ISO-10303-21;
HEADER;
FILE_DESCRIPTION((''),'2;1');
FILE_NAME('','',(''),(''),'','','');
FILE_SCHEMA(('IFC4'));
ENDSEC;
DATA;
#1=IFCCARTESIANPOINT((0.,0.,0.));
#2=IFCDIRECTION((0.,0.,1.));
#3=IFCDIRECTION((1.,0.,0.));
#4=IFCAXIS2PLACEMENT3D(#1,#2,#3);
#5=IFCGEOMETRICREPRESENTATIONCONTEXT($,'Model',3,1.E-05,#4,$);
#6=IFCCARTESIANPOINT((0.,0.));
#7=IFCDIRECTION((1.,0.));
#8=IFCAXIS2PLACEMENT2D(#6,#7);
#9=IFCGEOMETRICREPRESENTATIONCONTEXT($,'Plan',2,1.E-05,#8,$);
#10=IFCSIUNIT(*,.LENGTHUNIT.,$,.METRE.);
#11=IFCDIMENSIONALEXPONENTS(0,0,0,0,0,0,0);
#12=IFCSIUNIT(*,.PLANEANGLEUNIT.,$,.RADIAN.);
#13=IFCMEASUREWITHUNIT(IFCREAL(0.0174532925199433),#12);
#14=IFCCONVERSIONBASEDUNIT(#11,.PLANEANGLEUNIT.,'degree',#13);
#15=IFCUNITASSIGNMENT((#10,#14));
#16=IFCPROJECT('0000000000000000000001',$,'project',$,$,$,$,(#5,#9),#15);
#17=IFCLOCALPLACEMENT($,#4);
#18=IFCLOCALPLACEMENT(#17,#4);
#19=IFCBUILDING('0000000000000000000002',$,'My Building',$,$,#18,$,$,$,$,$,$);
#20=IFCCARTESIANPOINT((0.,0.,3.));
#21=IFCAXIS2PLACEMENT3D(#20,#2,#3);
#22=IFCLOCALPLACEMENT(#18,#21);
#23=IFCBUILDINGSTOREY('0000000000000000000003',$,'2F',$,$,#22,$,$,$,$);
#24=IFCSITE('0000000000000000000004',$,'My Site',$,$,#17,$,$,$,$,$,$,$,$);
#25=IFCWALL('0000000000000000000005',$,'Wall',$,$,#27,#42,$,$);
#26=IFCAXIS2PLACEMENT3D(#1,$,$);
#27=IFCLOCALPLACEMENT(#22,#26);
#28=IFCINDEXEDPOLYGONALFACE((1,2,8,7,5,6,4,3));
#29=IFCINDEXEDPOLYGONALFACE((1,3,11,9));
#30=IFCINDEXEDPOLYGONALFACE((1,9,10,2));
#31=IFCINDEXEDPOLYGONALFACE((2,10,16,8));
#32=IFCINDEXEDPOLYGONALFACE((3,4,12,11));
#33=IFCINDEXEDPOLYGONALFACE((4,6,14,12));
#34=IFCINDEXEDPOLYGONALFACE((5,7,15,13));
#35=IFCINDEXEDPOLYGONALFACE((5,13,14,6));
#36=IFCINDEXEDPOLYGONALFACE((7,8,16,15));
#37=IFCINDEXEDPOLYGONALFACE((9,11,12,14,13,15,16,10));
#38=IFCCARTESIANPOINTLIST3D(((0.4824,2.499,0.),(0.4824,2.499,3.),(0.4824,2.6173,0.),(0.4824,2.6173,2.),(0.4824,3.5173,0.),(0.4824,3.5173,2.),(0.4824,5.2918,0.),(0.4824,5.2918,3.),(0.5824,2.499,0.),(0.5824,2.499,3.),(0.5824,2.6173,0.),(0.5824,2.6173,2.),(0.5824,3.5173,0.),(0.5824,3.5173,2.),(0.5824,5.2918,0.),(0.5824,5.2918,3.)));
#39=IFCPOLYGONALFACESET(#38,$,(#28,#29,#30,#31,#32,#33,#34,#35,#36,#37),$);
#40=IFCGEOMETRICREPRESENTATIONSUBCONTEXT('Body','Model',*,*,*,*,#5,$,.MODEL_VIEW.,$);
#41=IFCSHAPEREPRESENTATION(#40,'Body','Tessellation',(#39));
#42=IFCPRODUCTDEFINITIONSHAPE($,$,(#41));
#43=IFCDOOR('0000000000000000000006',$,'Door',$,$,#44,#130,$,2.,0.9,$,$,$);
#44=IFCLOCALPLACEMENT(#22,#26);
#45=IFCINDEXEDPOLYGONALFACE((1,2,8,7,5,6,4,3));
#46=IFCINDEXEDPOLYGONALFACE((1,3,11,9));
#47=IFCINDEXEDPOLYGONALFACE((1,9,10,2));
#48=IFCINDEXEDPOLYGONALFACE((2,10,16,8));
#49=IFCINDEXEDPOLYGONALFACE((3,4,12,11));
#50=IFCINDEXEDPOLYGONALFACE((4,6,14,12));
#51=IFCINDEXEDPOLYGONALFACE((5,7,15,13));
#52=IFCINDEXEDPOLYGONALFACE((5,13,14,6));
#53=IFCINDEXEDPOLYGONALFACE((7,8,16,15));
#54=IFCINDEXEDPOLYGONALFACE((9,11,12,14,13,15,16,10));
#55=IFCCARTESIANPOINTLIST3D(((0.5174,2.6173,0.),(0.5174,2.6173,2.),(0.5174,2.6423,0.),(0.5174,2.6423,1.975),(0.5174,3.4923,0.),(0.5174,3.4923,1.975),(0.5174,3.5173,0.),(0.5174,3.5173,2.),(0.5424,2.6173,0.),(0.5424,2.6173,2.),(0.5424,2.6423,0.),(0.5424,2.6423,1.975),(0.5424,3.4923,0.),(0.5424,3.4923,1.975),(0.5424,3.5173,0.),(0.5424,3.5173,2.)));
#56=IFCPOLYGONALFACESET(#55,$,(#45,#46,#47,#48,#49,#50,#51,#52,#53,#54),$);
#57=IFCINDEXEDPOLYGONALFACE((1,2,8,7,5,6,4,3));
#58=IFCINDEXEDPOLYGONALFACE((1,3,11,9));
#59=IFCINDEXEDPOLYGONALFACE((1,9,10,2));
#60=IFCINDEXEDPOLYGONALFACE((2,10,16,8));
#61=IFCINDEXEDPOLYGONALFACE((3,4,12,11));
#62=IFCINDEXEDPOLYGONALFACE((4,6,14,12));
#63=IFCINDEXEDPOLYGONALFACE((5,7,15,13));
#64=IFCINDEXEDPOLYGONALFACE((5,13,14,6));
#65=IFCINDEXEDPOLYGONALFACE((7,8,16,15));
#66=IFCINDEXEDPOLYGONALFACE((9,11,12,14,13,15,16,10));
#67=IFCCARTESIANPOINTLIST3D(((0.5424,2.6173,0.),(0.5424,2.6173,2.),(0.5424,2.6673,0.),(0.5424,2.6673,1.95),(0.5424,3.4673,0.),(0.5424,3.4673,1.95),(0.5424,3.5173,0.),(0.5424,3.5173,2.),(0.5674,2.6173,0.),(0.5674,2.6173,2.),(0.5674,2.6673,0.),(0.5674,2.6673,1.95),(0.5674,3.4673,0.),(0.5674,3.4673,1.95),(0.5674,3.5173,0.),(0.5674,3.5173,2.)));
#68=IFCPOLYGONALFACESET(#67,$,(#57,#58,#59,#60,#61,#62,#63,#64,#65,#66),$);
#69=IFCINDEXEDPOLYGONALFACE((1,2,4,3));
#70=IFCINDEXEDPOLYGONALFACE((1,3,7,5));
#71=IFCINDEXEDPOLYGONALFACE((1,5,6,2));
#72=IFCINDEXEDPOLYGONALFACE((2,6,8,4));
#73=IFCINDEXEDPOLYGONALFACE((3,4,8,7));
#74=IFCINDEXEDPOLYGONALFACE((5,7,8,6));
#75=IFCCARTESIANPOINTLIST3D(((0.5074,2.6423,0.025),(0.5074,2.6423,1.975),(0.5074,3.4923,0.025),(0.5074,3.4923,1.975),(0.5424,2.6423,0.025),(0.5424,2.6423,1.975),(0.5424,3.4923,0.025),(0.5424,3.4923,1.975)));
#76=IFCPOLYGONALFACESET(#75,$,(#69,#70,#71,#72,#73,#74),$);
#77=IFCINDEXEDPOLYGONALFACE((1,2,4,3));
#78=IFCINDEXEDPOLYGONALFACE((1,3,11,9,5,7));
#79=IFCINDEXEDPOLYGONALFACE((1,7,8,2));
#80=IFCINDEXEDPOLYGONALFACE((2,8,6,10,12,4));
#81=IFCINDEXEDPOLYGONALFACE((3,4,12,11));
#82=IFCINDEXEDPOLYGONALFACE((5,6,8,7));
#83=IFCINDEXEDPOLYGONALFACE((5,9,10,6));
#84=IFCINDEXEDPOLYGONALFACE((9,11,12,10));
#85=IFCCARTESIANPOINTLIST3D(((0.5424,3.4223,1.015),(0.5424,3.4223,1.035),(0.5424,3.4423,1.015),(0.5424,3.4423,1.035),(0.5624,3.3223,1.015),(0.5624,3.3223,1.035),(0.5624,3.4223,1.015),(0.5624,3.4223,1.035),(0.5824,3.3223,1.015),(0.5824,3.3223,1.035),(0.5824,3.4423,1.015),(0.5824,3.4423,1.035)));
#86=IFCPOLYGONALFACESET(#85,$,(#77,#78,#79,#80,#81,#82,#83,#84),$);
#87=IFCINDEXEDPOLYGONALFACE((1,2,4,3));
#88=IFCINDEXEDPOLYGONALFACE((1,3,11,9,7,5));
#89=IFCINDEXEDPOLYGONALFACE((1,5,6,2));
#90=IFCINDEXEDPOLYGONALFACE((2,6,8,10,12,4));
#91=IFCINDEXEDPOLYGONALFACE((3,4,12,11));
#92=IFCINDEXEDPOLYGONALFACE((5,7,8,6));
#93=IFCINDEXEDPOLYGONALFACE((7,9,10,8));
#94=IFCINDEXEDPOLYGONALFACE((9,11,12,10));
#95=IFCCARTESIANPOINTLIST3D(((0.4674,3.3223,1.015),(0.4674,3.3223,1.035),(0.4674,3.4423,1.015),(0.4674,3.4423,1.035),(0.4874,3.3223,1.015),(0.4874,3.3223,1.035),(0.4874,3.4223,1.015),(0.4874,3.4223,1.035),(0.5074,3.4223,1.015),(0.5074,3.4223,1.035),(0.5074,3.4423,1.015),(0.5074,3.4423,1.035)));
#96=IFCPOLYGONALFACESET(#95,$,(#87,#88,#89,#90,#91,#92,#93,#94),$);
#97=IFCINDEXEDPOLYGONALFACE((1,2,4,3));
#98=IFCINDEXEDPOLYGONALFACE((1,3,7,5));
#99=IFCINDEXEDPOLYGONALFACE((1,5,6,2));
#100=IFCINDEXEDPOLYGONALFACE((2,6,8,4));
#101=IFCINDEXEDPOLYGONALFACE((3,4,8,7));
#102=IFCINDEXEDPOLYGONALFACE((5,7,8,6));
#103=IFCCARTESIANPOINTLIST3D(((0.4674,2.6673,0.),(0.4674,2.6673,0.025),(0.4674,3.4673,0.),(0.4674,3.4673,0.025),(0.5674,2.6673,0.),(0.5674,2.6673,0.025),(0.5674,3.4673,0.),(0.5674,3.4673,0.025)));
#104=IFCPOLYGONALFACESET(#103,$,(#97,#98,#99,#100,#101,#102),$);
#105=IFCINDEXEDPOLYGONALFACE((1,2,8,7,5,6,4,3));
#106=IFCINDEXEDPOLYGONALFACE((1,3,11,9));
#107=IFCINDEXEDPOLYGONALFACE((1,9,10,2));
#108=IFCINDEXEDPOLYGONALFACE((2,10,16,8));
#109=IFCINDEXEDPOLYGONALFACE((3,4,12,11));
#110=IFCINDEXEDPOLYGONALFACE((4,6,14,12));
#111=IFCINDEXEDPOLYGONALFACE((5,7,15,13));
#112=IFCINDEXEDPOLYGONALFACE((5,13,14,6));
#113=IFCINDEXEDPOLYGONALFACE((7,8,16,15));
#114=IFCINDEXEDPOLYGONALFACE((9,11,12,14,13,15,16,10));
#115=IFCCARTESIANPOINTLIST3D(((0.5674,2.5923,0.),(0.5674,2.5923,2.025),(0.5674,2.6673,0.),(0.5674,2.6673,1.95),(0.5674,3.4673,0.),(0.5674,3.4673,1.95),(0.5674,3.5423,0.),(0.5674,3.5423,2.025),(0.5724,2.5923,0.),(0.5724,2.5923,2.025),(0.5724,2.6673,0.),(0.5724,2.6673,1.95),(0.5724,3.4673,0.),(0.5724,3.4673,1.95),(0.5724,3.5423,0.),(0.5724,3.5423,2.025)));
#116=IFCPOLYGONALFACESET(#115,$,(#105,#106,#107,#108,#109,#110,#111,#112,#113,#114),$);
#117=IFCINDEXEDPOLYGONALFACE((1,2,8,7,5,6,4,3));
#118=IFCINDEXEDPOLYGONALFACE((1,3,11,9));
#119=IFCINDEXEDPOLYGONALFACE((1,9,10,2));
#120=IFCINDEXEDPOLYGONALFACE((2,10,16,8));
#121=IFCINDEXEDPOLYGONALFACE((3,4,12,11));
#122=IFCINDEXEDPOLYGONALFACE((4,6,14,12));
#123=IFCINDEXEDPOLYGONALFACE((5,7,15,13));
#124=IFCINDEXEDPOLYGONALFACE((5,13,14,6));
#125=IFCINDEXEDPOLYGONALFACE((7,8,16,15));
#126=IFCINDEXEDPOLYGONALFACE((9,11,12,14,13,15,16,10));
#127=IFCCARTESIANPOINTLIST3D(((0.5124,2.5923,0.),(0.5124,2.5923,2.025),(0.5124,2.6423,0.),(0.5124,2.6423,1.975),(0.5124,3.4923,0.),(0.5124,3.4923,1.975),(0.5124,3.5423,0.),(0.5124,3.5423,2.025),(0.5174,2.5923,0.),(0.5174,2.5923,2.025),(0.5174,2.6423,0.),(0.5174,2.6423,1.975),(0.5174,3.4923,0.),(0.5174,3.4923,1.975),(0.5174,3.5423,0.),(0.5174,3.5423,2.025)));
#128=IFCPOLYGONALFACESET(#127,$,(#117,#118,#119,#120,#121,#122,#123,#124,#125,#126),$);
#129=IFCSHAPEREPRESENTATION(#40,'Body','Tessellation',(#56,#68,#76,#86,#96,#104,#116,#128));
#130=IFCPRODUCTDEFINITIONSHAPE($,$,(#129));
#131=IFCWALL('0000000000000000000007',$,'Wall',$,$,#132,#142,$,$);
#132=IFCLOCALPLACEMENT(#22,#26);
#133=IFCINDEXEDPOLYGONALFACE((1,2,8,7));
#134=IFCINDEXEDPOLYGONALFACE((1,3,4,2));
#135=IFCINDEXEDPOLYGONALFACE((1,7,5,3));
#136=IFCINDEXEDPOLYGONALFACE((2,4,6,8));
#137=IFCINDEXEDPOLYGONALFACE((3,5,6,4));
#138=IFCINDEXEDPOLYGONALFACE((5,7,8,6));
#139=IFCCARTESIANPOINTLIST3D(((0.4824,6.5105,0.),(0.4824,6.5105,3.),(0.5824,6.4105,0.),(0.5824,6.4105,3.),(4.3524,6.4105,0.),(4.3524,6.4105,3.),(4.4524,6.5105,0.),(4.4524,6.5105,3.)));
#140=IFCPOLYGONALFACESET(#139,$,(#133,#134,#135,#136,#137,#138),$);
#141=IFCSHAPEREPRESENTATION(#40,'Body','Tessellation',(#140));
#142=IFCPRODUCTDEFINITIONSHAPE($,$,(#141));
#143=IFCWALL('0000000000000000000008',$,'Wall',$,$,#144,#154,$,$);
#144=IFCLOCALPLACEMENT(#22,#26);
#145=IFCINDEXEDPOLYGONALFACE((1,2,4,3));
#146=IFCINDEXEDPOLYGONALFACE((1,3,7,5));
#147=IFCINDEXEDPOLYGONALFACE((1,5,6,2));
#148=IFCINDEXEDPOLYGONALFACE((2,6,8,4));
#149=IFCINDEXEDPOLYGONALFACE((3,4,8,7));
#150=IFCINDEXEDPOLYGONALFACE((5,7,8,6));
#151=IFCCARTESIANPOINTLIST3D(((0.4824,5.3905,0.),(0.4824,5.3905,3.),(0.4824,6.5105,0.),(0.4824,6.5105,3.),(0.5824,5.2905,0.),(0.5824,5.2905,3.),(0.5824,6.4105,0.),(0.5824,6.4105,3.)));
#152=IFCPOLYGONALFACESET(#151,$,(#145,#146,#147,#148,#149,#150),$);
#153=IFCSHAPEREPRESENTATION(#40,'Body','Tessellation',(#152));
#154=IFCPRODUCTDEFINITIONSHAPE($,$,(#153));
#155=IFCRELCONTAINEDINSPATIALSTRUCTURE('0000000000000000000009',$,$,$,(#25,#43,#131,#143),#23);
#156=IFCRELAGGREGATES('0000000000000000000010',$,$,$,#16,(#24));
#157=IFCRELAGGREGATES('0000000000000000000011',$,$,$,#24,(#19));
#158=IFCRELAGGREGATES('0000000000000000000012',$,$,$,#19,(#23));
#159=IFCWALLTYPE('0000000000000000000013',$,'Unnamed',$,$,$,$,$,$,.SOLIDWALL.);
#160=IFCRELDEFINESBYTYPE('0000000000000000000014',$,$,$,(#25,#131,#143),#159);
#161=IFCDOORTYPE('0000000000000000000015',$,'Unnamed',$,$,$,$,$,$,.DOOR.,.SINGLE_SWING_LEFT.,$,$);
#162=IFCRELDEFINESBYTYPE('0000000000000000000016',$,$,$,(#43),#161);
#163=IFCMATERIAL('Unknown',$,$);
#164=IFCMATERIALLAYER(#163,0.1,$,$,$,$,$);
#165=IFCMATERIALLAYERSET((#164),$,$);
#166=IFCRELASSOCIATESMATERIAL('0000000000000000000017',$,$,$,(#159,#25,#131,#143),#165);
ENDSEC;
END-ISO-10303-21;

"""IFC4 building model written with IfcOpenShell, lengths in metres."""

from ifc_helpers import new_model, entity, si_unit, converted_unit, frame, origin_with_axes, origin_2d_with_axis, place, context, subcontext, project, spatial, line, indexed_curve, outline, extrude, shape, source, transform, mapped, material, layer, layer_set, layer_usage, type_object, type_shapes, element, fill, save


model = new_model("IFC4")

# Units and contexts
model_context = context("Model", 3, precision=1e-05, world=origin_with_axes())
plan_context = context("Plan", 2, precision=1e-05, world=origin_2d_with_axis())
body_context_1 = subcontext(model_context, "Body", "Model", "MODEL_VIEW")
body_context_2 = subcontext(plan_context, "Body", "Plan", "PLAN_VIEW")
ifc_project = project(units=[si_unit("LENGTHUNIT", "METRE"), converted_unit("PLANEANGLEUNIT", "degree", entity("IfcReal", 0.0174532925199433), si_unit("PLANEANGLEUNIT", "RADIAN"), dimensions=[0, 0, 0, 0, 0, 0, 0])], contexts=[model_context, plan_context])

# Site, building, storey
site_placement = place(None, origin_with_axes())
site = spatial("IfcSite", under=ifc_project, at=site_placement, Name="My Site")
building_placement = place(site_placement, origin_with_axes())
building = spatial("IfcBuilding", under=site, at=building_placement, Name="My Building")
storey_placement = place(building_placement, frame((0.0, 0.0, 3.0), z_axis=(0.0, 0.0, 1.0), x_axis=(1.0, 0.0, 0.0)))
storey = spatial("IfcBuildingStorey", under=building, at=storey_placement, Name="2F")

# Shared definitions
ifc_material = material(Name="Unknown")

# Wall, opening, door
ifc_layer = layer(ifc_material, 0.1)
ifc_layer_set = layer_set([ifc_layer])
wall_type = type_object("IfcWallType", Name="Unnamed", PredefinedType="SOLIDWALL", material=ifc_layer_set)
shared_shape_1 = source(origin_with_axes(), body_context_1, "Body", "SweptSolid", [
    extrude(outline(indexed_curve([(0.0, 0.0), (0.9, 0.0), (0.9, 2.0), (0.0, 2.0)], segments=[line(1, 2, 3, 4, 1)])), frame((0.0, -0.6, 0.0), z_axis=(0.0, -1.0, 0.0), x_axis=(1.0, 0.0, 0.0)), (0.0, 0.0, -1.0), 1.2),
])
door_type_1 = type_object("IfcDoorType", Name="Unnamed", OperationType="SINGLE_SWING_LEFT", PredefinedType="DOOR")
shared_shape_2 = source(origin_with_axes(), body_context_1, "Body", "SweptSolid", [
    extrude(outline(indexed_curve([(0.0, 0.0), (0.0, 2.0), (0.9, 2.0), (0.9, 0.0), (0.875, 0.0), (0.875, 1.975), (0.025, 1.975), (0.025, 0.0)], segments=[line(1, 2, 3, 4, 5, 6, 7, 8, 1)])), frame((0.0, 0.025, 0.0), z_axis=(0.0, -1.0, 0.0), x_axis=(1.0, 0.0, 0.0)), (0.0, 0.0, -1.0), 0.025),
    extrude(outline(indexed_curve([(0.0, 0.0), (0.0, 2.0), (0.9, 2.0), (0.9, 0.0), (0.85, 0.0), (0.85, 1.95), (0.05, 1.95), (0.05, 0.0)], segments=[line(1, 2, 3, 4, 5, 6, 7, 8, 1)])), frame((0.0, 0.0, 0.0), z_axis=(0.0, -1.0, 0.0), x_axis=(1.0, 0.0, 0.0)), (0.0, 0.0, -1.0), 0.025),
    extrude(outline(indexed_curve([(0.0, 0.0), (0.85, 0.0), (0.85, 0.035), (0.0, 0.035)], segments=[line(1, 2, 3, 4, 1)])), frame((0.025, 0.025, 0.025), z_axis=(0.0, 0.0, 1.0), x_axis=(1.0, 0.0, 0.0)), (0.0, 0.0, 1.0), 1.95),
    extrude(outline(indexed_curve([(0.0, 0.0), (0.0, -0.04), (-0.12, -0.04), (-0.12, -0.02), (-0.02, -0.02), (-0.02, 0.0)], segments=[line(1, 2, 3, 4, 5, 6, 1)])), frame((0.825, 0.025, 1.015), z_axis=(0.0, 0.0, 1.0), x_axis=(1.0, 0.0, 0.0)), (0.0, 0.0, 1.0), 0.02),
    extrude(outline(indexed_curve([(0.0, 0.0), (0.0, 0.04), (-0.12, 0.04), (-0.12, 0.02), (-0.02, 0.02), (-0.02, 0.0)], segments=[line(1, 2, 3, 4, 5, 6, 1)])), frame((0.825, 0.06, 1.015), z_axis=(0.0, 0.0, 1.0), x_axis=(1.0, 0.0, 0.0)), (0.0, 0.0, 1.0), 0.02),
    extrude(outline(indexed_curve([(0.0, 0.0), (0.8, 0.0), (0.8, 0.1), (0.0, 0.1)], segments=[line(1, 2, 3, 4, 1)])), frame((0.05, 0.0, 0.0), z_axis=(0.0, 0.0, 1.0), x_axis=(1.0, 0.0, 0.0)), (0.0, 0.0, 1.0), 0.025),
    extrude(outline(indexed_curve([(0.0, 0.0), (0.0, 2.025), (0.95, 2.025), (0.95, 0.0), (0.875, 0.0), (0.875, 1.95), (0.075, 1.95), (0.075, 0.0)], segments=[line(1, 2, 3, 4, 5, 6, 7, 8, 1)])), frame((-0.025, -0.005, 0.0), z_axis=(0.0, -1.0, 0.0), x_axis=(1.0, 0.0, 0.0)), (0.0, 0.0, -1.0), 0.005),
    extrude(outline(indexed_curve([(0.0, 0.0), (0.0, 2.025), (0.95, 2.025), (0.95, 0.0), (0.9, 0.0), (0.9, 1.975), (0.05, 1.975), (0.05, 0.0)], segments=[line(1, 2, 3, 4, 5, 6, 7, 8, 1)])), frame((-0.025, 0.05, 0.0), z_axis=(0.0, -1.0, 0.0), x_axis=(1.0, 0.0, 0.0)), (0.0, 0.0, -1.0), 0.005),
])
shared_shape_3 = source(origin_with_axes(), body_context_2, "Body", "Curve2D", [
    entity("IfcIndexedPolyCurve", entity("IfcCartesianPointList2D", [[0.0, 0.0], [0.0, 0.05], [0.025, 0.05], [0.025, 0.025], [0.05, 0.025], [0.05, 0.0]]), [entity("IfcLineIndex", [1, 2, 3, 4, 5, 6, 1])]),
    entity("IfcIndexedPolyCurve", entity("IfcCartesianPointList2D", [[0.9, 0.0], [0.9, 0.05], [0.875, 0.05], [0.875, 0.025], [0.85, 0.025], [0.85, 0.0]]), [entity("IfcLineIndex", [1, 2, 3, 4, 5, 6, 1])]),
    entity("IfcTrimmedCurve", entity("IfcEllipse", entity("IfcAxis2Placement2D", entity("IfcCartesianPoint", [0.06, 0.05]), entity("IfcDirection", [1.0, 0.0])), 0.815, 0.85), [entity("IfcCartesianPoint", [0.875, 0.05])], [entity("IfcCartesianPoint", [0.06, 0.9])], True, "CARTESIAN"),
    entity("IfcIndexedPolyCurve", entity("IfcCartesianPointList2D", [[0.025, 0.05], [0.06, 0.05], [0.06, 0.9], [0.025, 0.9]]), [entity("IfcLineIndex", [1, 2, 3, 4, 1])]),
])
type_shapes(door_type_1, [shared_shape_2, shared_shape_3])
ifc_layer_usage_1 = layer_usage(ifc_layer_set, "AXIS2", "POSITIVE", 0.0)
wall_1_placement = place(storey_placement, frame((0.4824, 5.2918, 0.0), z_axis=(0.0, 0.0, 1.0), x_axis=(0.0, -1.0, 0.0)))
wall_1 = element("IfcWall", 1, at=wall_1_placement, inside=storey, type_object=wall_type, material=ifc_layer_usage_1, Name="Wall", context=body_context_1, shape_type="SweptSolid", body=[
    extrude(outline(indexed_curve([(0.0, 0.0), (0.0, 0.1), (2.7929, 0.1), (2.7929, 0.0)], segments=[line(1, 2, 3, 4, 1)])), origin_with_axes(), (0.0, 0.0, 1.0), 3.0),
])
opening_1_placement = place(wall_1_placement, frame((1.7746, 0.0, 0.0), z_axis=(0.0, 0.0, 1.0), x_axis=(1.0, 0.0, 0.0)))
opening_1 = element("IfcOpeningElement", 2, at=opening_1_placement, cuts=wall_1, PredefinedType="OPENING", context=body_context_1, shape_type="MappedRepresentation", body=[
    mapped(shared_shape_1, transform((0.0, 0.0, 0.0), x_axis=(1.0, 0.0, 0.0), y_axis=(0.0, 1.0, 0.0), z_axis=(0.0, 0.0, 1.0), scale=1.0)),
])
door_1_placement = place(opening_1_placement, frame((0.9, 0.085, 0.0), z_axis=(0.0, 0.0, 1.0), x_axis=(-1.0, 0.0, 0.0)))
door_1 = element("IfcDoor", 3, at=door_1_placement, inside=storey, type_object=door_type_1, Name="Door", OverallHeight=2.0, OverallWidth=0.9, shapes=[
    shape(body_context_1, "Body", "MappedRepresentation", [mapped(shared_shape_2, transform((0.0, 0.0, 0.0), x_axis=(1.0, 0.0, 0.0), y_axis=(0.0, 1.0, 0.0), z_axis=(0.0, 0.0, 1.0), scale=1.0))]),
    shape(body_context_2, "Body", "MappedRepresentation", [mapped(shared_shape_3, transform((0.0, 0.0, 0.0), x_axis=(1.0, 0.0, 0.0), y_axis=(0.0, 1.0, 0.0), z_axis=(0.0, 0.0, 1.0), scale=1.0))]),
])
fill(opening_1, door_1)

# Walls
ifc_layer_usage_2 = layer_usage(ifc_layer_set, "AXIS2", "POSITIVE", 0.0)
wall_2_placement = place(storey_placement, frame((4.4524, 6.5105, 0.0), z_axis=(0.0, 0.0, 1.0), x_axis=(-1.0, 0.0, 0.0)))
element("IfcWall", 4, at=wall_2_placement, inside=storey, type_object=wall_type, material=ifc_layer_usage_2, Name="Wall", context=body_context_1, shape_type="SweptSolid", body=[
    extrude(outline(indexed_curve([(0.0, 0.0), (0.1, 0.1), (3.87, 0.1), (3.97, 0.0)], segments=[line(1, 2, 3, 4, 1)])), origin_with_axes(), (0.0, 0.0, 1.0), 3.0),
])
ifc_layer_usage_3 = layer_usage(ifc_layer_set, "AXIS2", "POSITIVE", 0.0)
wall_3_placement = place(storey_placement, frame((0.4824, 6.5105, 0.0), z_axis=(0.0, 0.0, 1.0), x_axis=(0.0, -1.0, 0.0)))
element("IfcWall", 5, at=wall_3_placement, inside=storey, type_object=wall_type, material=ifc_layer_usage_3, Name="Wall", context=body_context_1, shape_type="SweptSolid", body=[
    extrude(outline(indexed_curve([(0.0, 0.0), (0.1, 0.1), (1.22, 0.1), (1.12, 0.0)], segments=[line(1, 2, 3, 4, 1)])), origin_with_axes(), (0.0, 0.0, 1.0), 3.0),
])

save(model, "model.ifc")
